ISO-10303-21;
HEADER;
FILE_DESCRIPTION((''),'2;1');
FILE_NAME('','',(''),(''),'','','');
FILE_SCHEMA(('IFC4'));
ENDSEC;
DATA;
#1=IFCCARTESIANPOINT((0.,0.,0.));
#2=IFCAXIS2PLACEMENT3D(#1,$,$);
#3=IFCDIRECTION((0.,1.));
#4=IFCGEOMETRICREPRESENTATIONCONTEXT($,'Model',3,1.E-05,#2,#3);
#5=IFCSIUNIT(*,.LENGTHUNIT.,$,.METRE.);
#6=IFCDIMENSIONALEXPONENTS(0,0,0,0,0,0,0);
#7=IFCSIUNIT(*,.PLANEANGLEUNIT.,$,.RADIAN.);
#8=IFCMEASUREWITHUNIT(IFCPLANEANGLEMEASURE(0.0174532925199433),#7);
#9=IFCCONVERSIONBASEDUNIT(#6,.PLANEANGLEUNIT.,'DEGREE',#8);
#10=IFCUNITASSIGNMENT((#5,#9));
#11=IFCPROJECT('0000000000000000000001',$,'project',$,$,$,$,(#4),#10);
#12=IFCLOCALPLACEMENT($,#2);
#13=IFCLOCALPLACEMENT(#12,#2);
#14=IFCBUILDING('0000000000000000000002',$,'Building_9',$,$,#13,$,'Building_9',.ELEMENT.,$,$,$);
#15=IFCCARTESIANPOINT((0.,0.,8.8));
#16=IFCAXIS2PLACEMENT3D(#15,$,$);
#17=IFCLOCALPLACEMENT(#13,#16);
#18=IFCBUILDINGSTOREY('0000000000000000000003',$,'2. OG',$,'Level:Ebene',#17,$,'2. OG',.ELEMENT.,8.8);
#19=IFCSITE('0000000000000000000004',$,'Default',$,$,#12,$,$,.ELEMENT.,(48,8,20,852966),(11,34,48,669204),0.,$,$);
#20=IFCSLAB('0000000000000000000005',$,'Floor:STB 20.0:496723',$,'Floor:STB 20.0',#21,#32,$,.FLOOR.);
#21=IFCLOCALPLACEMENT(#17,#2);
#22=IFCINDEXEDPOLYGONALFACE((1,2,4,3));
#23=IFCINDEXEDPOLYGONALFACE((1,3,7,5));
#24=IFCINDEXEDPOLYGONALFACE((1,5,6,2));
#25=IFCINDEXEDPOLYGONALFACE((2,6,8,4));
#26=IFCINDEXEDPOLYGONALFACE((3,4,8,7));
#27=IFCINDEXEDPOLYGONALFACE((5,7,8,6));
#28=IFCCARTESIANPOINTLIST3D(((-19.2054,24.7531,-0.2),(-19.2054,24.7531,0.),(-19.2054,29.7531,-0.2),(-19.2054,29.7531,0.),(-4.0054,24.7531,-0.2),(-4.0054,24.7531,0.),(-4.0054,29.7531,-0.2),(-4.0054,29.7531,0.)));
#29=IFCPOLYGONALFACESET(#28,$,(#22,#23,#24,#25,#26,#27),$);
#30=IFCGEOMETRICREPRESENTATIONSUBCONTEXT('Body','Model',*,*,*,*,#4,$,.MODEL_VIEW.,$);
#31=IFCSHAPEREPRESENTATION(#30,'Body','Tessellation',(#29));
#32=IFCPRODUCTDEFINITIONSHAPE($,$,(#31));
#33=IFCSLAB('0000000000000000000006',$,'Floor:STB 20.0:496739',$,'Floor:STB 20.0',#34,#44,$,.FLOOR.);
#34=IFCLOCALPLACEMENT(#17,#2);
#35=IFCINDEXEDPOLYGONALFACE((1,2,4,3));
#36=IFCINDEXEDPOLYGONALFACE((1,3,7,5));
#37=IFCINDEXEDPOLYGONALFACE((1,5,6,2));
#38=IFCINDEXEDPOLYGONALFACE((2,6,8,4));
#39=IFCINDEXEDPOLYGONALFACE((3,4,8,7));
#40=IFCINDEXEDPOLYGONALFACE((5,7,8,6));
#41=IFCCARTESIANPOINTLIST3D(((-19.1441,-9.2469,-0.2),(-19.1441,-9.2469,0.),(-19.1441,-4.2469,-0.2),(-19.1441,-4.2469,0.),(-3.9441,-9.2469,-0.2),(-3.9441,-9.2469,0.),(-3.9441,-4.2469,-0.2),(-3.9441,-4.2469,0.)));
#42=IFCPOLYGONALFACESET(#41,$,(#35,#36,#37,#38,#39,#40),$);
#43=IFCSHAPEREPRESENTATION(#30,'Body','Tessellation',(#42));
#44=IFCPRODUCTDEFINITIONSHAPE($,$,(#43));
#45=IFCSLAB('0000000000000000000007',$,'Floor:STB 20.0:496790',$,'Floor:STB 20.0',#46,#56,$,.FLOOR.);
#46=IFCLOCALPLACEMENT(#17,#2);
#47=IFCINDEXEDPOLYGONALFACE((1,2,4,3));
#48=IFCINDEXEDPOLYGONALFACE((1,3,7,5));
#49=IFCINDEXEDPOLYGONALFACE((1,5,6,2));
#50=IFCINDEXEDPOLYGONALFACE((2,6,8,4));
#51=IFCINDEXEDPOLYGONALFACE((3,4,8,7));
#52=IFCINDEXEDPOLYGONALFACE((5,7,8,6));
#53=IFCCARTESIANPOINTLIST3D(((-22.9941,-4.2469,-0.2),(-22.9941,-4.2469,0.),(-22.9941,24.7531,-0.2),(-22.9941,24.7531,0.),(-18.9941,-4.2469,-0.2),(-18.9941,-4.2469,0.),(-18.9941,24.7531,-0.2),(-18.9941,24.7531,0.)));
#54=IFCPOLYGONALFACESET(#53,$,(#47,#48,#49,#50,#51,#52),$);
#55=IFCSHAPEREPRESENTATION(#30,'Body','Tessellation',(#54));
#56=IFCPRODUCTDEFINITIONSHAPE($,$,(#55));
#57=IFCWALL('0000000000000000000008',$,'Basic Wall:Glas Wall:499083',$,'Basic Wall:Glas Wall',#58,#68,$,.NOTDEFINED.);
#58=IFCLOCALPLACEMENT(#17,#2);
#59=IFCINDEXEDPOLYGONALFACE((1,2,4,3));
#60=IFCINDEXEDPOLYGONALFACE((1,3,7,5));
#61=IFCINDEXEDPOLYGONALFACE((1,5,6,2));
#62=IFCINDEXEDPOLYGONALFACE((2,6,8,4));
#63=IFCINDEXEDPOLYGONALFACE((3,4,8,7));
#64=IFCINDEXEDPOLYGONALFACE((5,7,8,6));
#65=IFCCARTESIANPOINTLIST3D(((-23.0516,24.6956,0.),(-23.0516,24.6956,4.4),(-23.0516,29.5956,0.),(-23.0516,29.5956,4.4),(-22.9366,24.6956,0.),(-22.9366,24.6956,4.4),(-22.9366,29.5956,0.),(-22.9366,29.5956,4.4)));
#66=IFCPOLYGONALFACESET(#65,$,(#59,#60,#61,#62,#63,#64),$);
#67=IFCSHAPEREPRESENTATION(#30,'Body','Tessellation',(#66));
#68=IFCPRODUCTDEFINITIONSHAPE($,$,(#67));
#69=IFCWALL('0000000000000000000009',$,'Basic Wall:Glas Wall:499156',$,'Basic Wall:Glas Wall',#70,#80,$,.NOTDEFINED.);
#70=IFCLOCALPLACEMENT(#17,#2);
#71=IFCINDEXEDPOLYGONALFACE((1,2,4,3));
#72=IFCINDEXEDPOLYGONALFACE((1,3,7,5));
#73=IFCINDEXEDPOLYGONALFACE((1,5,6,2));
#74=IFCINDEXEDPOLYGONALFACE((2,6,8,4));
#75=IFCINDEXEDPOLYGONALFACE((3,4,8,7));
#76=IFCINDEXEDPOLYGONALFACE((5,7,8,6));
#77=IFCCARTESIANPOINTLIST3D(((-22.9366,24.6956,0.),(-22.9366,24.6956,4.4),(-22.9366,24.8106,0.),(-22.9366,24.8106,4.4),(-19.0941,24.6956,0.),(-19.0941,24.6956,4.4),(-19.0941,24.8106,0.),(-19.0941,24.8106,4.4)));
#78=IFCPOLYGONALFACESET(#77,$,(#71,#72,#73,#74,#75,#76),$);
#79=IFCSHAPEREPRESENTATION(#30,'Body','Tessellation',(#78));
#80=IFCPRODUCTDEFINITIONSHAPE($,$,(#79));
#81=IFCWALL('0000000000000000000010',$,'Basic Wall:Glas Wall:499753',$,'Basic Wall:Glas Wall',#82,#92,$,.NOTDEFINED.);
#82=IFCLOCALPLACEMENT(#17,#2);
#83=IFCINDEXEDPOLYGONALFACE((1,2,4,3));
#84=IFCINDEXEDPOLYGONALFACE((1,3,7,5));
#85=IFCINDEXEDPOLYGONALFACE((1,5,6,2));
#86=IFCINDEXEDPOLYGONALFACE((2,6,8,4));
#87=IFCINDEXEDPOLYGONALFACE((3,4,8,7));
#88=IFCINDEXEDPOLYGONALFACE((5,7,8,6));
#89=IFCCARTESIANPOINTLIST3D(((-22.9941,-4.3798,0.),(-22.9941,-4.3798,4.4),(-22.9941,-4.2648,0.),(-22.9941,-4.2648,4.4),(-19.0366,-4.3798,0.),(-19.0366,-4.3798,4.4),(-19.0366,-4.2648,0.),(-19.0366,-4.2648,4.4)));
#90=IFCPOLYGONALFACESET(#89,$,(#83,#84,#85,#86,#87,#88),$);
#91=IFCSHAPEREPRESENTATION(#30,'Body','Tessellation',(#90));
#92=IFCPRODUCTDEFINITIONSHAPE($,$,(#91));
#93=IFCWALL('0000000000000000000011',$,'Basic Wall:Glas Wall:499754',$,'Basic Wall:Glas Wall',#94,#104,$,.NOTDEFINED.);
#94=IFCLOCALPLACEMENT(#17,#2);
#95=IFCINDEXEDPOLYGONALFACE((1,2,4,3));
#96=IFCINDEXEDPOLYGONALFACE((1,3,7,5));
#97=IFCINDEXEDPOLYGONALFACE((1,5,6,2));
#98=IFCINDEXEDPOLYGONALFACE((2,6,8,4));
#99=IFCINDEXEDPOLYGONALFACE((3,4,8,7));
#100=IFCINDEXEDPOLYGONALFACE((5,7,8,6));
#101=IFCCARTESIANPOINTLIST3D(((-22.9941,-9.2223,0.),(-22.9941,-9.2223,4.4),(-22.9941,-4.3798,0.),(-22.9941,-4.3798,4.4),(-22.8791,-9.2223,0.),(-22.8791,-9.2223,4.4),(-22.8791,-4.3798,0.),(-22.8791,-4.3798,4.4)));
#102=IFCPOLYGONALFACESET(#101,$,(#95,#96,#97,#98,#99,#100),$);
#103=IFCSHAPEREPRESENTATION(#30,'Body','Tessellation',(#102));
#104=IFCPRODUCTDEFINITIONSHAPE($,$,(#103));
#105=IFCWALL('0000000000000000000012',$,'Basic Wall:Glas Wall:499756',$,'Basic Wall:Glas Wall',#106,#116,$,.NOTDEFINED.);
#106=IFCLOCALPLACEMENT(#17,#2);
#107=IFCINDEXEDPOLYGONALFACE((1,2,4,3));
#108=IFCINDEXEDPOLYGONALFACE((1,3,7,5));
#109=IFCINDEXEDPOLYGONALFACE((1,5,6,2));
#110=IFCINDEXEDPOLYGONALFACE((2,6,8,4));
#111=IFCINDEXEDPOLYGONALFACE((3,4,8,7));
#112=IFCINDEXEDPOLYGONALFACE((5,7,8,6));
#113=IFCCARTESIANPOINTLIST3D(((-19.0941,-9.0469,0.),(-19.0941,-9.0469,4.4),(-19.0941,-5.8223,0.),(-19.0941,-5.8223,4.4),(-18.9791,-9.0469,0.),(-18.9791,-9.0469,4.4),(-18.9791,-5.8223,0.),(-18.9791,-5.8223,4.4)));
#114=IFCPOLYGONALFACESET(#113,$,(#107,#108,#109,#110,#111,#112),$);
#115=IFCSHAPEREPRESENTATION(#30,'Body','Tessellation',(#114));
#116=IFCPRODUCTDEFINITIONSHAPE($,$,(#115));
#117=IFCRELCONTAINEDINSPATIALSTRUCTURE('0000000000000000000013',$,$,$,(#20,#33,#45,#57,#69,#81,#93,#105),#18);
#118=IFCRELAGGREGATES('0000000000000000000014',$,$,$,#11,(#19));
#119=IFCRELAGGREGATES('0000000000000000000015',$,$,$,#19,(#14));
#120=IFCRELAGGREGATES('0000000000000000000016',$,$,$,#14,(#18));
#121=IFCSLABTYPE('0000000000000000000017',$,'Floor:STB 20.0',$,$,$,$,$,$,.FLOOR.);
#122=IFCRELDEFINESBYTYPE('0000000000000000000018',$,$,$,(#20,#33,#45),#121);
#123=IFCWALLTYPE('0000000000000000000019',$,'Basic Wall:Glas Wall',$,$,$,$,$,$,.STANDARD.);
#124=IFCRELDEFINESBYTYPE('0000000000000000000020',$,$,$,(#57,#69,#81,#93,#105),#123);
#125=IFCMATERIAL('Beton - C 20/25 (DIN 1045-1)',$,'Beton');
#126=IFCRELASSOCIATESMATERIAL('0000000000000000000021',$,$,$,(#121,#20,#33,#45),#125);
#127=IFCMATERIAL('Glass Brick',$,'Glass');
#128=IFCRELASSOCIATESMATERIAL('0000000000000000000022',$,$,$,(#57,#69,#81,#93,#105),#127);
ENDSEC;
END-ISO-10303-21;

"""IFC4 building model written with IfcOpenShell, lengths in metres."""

from ifc_helpers import new_model, entity, si_unit, converted_unit, direction, frame, origin, place, context, subcontext, project, spatial, indexed_curve, outline, extrude, material, type_object, element, save


model = new_model("IFC4")

# Units and contexts
model_context = context("Model", 3, precision=1e-05, world=origin(), true_north=direction((0.0, 1.0)))
body_context = subcontext(model_context, "Body", "Model", "MODEL_VIEW")
ifc_project = project(units=[si_unit("LENGTHUNIT", "METRE"), converted_unit("PLANEANGLEUNIT", "DEGREE", entity("IfcPlaneAngleMeasure", 0.0174532925199433), si_unit("PLANEANGLEUNIT", "RADIAN"), dimensions=[0, 0, 0, 0, 0, 0, 0])], contexts=[model_context])

# Site, building, storey
site_placement = place(None, origin())
site = spatial("IfcSite", under=ifc_project, at=site_placement, Name="Default", CompositionType="ELEMENT", RefLatitude=(48, 8, 20, 852966), RefLongitude=(11, 34, 48, 669204), RefElevation=0.0)
building_placement = place(site_placement, origin())
building = spatial("IfcBuilding", under=site, at=building_placement, Name="Building_9", LongName="Building_9", CompositionType="ELEMENT")
storey_placement = place(building_placement, frame((0.0, 0.0, 8.8)))
storey = spatial("IfcBuildingStorey", under=building, at=storey_placement, Name="2. OG", ObjectType="Level:Ebene", LongName="2. OG", CompositionType="ELEMENT", Elevation=8.8)

# Slabs
ifc_material_1 = material(Name="Beton - C 20/25 (DIN 1045-1)", Category="Beton")
slab_type = type_object("IfcSlabType", Name="Floor:STB 20.0", PredefinedType="FLOOR", material=ifc_material_1)
slab_1_placement = place(storey_placement, origin())
element("IfcSlab", 1, at=slab_1_placement, inside=storey, type_object=slab_type, material=ifc_material_1, Name="Floor:STB 20.0:496723", ObjectType="Floor:STB 20.0", PredefinedType="FLOOR", context=body_context, shape_type="SweptSolid", body=[
    extrude(outline(indexed_curve([(-2.5, -7.6), (2.5, -7.6), (2.5, 7.6), (-2.5, 7.6), (-2.5, -7.6)], self_intersect=False)), frame((-11.6054, 27.2531, 0.0), z_axis=(0.0, 0.0, -1.0), x_axis=(0.0, 1.0, 0.0)), (0.0, 0.0, 1.0), 0.2),
])
slab_2_placement = place(storey_placement, origin())
element("IfcSlab", 2, at=slab_2_placement, inside=storey, type_object=slab_type, material=ifc_material_1, Name="Floor:STB 20.0:496739", ObjectType="Floor:STB 20.0", PredefinedType="FLOOR", context=body_context, shape_type="SweptSolid", body=[
    extrude(outline(indexed_curve([(-2.5, -7.6), (2.5, -7.6), (2.5, 7.6), (-2.5, 7.6), (-2.5, -7.6)], self_intersect=False)), frame((-11.5441, -6.7469, 0.0), z_axis=(0.0, 0.0, -1.0), x_axis=(0.0, 1.0, 0.0)), (0.0, 0.0, 1.0), 0.2),
])
slab_3_placement = place(storey_placement, origin())
element("IfcSlab", 3, at=slab_3_placement, inside=storey, type_object=slab_type, material=ifc_material_1, Name="Floor:STB 20.0:496790", ObjectType="Floor:STB 20.0", PredefinedType="FLOOR", context=body_context, shape_type="SweptSolid", body=[
    extrude(outline(indexed_curve([(-14.5, -2.0), (14.5, -2.0), (14.5, 2.0), (-14.5, 2.0), (-14.5, -2.0)], self_intersect=False)), frame((-20.9941, 10.2531, 0.0), z_axis=(0.0, 0.0, -1.0), x_axis=(0.0, 1.0, 0.0)), (0.0, 0.0, 1.0), 0.2),
])

# Walls
ifc_material_2 = material(Name="Glass Brick", Category="Glass")
wall_type = type_object("IfcWallType", Name="Basic Wall:Glas Wall", PredefinedType="STANDARD")
wall_1_placement = place(storey_placement, frame((-22.9941, 29.5956, 0.0), z_axis=(0.0, 0.0, 1.0), x_axis=(0.0, -1.0, 0.0)))
element("IfcWall", 4, at=wall_1_placement, inside=storey, type_object=wall_type, material=ifc_material_2, Name="Basic Wall:Glas Wall:499083", ObjectType="Basic Wall:Glas Wall", PredefinedType="NOTDEFINED", context=body_context, shape_type="SweptSolid", body=[
    extrude(outline(indexed_curve([(4.9, 0.0575), (0.0, 0.0575), (0.0, -0.0575), (4.9, -0.0575), (4.9, 0.0575)], self_intersect=False)), origin(), (0.0, 0.0, 1.0), 4.4),
])
wall_2_placement = place(storey_placement, frame((-22.9366, 24.7531, 0.0)))
element("IfcWall", 5, at=wall_2_placement, inside=storey, type_object=wall_type, material=ifc_material_2, Name="Basic Wall:Glas Wall:499156", ObjectType="Basic Wall:Glas Wall", PredefinedType="NOTDEFINED", context=body_context, shape_type="SweptSolid", body=[
    extrude(outline(indexed_curve([(3.8425, 0.0575), (0.0, 0.0575), (0.0, -0.0575), (3.8425, -0.0575), (3.8425, 0.0575)], self_intersect=False)), origin(), (0.0, 0.0, 1.0), 4.4),
])
wall_3_placement = place(storey_placement, frame((-19.0366, -4.3223, 0.0), z_axis=(0.0, 0.0, 1.0), x_axis=(-1.0, 0.0, 0.0)))
element("IfcWall", 6, at=wall_3_placement, inside=storey, type_object=wall_type, material=ifc_material_2, Name="Basic Wall:Glas Wall:499753", ObjectType="Basic Wall:Glas Wall", PredefinedType="NOTDEFINED", context=body_context, shape_type="SweptSolid", body=[
    extrude(outline(indexed_curve([(3.9575, 0.0575), (0.0, 0.0575), (0.0, -0.0575), (3.9575, -0.0575), (3.9575, 0.0575)], self_intersect=False)), origin(), (0.0, 0.0, 1.0), 4.4),
])
wall_4_placement = place(storey_placement, frame((-22.9366, -4.3798, 0.0), z_axis=(0.0, 0.0, 1.0), x_axis=(0.0, -1.0, 0.0)))
element("IfcWall", 7, at=wall_4_placement, inside=storey, type_object=wall_type, material=ifc_material_2, Name="Basic Wall:Glas Wall:499754", ObjectType="Basic Wall:Glas Wall", PredefinedType="NOTDEFINED", context=body_context, shape_type="SweptSolid", body=[
    extrude(outline(indexed_curve([(4.8425, 0.0575), (0.0, 0.0575), (0.0, -0.0575), (4.8425, -0.0575), (4.8425, 0.0575)], self_intersect=False)), origin(), (0.0, 0.0, 1.0), 4.4),
])
wall_5_placement = place(storey_placement, frame((-19.0366, -9.0469, 0.0), z_axis=(0.0, 0.0, 1.0), x_axis=(0.0, 1.0, 0.0)))
element("IfcWall", 8, at=wall_5_placement, inside=storey, type_object=wall_type, material=ifc_material_2, Name="Basic Wall:Glas Wall:499756", ObjectType="Basic Wall:Glas Wall", PredefinedType="NOTDEFINED", context=body_context, shape_type="SweptSolid", body=[
    extrude(outline(indexed_curve([(3.2246, 0.0575), (0.0, 0.0575), (0.0, -0.0575), (3.2246, -0.0575), (3.2246, 0.0575)], self_intersect=False)), origin(), (0.0, 0.0, 1.0), 4.4),
])

save(model, "model.ifc")
